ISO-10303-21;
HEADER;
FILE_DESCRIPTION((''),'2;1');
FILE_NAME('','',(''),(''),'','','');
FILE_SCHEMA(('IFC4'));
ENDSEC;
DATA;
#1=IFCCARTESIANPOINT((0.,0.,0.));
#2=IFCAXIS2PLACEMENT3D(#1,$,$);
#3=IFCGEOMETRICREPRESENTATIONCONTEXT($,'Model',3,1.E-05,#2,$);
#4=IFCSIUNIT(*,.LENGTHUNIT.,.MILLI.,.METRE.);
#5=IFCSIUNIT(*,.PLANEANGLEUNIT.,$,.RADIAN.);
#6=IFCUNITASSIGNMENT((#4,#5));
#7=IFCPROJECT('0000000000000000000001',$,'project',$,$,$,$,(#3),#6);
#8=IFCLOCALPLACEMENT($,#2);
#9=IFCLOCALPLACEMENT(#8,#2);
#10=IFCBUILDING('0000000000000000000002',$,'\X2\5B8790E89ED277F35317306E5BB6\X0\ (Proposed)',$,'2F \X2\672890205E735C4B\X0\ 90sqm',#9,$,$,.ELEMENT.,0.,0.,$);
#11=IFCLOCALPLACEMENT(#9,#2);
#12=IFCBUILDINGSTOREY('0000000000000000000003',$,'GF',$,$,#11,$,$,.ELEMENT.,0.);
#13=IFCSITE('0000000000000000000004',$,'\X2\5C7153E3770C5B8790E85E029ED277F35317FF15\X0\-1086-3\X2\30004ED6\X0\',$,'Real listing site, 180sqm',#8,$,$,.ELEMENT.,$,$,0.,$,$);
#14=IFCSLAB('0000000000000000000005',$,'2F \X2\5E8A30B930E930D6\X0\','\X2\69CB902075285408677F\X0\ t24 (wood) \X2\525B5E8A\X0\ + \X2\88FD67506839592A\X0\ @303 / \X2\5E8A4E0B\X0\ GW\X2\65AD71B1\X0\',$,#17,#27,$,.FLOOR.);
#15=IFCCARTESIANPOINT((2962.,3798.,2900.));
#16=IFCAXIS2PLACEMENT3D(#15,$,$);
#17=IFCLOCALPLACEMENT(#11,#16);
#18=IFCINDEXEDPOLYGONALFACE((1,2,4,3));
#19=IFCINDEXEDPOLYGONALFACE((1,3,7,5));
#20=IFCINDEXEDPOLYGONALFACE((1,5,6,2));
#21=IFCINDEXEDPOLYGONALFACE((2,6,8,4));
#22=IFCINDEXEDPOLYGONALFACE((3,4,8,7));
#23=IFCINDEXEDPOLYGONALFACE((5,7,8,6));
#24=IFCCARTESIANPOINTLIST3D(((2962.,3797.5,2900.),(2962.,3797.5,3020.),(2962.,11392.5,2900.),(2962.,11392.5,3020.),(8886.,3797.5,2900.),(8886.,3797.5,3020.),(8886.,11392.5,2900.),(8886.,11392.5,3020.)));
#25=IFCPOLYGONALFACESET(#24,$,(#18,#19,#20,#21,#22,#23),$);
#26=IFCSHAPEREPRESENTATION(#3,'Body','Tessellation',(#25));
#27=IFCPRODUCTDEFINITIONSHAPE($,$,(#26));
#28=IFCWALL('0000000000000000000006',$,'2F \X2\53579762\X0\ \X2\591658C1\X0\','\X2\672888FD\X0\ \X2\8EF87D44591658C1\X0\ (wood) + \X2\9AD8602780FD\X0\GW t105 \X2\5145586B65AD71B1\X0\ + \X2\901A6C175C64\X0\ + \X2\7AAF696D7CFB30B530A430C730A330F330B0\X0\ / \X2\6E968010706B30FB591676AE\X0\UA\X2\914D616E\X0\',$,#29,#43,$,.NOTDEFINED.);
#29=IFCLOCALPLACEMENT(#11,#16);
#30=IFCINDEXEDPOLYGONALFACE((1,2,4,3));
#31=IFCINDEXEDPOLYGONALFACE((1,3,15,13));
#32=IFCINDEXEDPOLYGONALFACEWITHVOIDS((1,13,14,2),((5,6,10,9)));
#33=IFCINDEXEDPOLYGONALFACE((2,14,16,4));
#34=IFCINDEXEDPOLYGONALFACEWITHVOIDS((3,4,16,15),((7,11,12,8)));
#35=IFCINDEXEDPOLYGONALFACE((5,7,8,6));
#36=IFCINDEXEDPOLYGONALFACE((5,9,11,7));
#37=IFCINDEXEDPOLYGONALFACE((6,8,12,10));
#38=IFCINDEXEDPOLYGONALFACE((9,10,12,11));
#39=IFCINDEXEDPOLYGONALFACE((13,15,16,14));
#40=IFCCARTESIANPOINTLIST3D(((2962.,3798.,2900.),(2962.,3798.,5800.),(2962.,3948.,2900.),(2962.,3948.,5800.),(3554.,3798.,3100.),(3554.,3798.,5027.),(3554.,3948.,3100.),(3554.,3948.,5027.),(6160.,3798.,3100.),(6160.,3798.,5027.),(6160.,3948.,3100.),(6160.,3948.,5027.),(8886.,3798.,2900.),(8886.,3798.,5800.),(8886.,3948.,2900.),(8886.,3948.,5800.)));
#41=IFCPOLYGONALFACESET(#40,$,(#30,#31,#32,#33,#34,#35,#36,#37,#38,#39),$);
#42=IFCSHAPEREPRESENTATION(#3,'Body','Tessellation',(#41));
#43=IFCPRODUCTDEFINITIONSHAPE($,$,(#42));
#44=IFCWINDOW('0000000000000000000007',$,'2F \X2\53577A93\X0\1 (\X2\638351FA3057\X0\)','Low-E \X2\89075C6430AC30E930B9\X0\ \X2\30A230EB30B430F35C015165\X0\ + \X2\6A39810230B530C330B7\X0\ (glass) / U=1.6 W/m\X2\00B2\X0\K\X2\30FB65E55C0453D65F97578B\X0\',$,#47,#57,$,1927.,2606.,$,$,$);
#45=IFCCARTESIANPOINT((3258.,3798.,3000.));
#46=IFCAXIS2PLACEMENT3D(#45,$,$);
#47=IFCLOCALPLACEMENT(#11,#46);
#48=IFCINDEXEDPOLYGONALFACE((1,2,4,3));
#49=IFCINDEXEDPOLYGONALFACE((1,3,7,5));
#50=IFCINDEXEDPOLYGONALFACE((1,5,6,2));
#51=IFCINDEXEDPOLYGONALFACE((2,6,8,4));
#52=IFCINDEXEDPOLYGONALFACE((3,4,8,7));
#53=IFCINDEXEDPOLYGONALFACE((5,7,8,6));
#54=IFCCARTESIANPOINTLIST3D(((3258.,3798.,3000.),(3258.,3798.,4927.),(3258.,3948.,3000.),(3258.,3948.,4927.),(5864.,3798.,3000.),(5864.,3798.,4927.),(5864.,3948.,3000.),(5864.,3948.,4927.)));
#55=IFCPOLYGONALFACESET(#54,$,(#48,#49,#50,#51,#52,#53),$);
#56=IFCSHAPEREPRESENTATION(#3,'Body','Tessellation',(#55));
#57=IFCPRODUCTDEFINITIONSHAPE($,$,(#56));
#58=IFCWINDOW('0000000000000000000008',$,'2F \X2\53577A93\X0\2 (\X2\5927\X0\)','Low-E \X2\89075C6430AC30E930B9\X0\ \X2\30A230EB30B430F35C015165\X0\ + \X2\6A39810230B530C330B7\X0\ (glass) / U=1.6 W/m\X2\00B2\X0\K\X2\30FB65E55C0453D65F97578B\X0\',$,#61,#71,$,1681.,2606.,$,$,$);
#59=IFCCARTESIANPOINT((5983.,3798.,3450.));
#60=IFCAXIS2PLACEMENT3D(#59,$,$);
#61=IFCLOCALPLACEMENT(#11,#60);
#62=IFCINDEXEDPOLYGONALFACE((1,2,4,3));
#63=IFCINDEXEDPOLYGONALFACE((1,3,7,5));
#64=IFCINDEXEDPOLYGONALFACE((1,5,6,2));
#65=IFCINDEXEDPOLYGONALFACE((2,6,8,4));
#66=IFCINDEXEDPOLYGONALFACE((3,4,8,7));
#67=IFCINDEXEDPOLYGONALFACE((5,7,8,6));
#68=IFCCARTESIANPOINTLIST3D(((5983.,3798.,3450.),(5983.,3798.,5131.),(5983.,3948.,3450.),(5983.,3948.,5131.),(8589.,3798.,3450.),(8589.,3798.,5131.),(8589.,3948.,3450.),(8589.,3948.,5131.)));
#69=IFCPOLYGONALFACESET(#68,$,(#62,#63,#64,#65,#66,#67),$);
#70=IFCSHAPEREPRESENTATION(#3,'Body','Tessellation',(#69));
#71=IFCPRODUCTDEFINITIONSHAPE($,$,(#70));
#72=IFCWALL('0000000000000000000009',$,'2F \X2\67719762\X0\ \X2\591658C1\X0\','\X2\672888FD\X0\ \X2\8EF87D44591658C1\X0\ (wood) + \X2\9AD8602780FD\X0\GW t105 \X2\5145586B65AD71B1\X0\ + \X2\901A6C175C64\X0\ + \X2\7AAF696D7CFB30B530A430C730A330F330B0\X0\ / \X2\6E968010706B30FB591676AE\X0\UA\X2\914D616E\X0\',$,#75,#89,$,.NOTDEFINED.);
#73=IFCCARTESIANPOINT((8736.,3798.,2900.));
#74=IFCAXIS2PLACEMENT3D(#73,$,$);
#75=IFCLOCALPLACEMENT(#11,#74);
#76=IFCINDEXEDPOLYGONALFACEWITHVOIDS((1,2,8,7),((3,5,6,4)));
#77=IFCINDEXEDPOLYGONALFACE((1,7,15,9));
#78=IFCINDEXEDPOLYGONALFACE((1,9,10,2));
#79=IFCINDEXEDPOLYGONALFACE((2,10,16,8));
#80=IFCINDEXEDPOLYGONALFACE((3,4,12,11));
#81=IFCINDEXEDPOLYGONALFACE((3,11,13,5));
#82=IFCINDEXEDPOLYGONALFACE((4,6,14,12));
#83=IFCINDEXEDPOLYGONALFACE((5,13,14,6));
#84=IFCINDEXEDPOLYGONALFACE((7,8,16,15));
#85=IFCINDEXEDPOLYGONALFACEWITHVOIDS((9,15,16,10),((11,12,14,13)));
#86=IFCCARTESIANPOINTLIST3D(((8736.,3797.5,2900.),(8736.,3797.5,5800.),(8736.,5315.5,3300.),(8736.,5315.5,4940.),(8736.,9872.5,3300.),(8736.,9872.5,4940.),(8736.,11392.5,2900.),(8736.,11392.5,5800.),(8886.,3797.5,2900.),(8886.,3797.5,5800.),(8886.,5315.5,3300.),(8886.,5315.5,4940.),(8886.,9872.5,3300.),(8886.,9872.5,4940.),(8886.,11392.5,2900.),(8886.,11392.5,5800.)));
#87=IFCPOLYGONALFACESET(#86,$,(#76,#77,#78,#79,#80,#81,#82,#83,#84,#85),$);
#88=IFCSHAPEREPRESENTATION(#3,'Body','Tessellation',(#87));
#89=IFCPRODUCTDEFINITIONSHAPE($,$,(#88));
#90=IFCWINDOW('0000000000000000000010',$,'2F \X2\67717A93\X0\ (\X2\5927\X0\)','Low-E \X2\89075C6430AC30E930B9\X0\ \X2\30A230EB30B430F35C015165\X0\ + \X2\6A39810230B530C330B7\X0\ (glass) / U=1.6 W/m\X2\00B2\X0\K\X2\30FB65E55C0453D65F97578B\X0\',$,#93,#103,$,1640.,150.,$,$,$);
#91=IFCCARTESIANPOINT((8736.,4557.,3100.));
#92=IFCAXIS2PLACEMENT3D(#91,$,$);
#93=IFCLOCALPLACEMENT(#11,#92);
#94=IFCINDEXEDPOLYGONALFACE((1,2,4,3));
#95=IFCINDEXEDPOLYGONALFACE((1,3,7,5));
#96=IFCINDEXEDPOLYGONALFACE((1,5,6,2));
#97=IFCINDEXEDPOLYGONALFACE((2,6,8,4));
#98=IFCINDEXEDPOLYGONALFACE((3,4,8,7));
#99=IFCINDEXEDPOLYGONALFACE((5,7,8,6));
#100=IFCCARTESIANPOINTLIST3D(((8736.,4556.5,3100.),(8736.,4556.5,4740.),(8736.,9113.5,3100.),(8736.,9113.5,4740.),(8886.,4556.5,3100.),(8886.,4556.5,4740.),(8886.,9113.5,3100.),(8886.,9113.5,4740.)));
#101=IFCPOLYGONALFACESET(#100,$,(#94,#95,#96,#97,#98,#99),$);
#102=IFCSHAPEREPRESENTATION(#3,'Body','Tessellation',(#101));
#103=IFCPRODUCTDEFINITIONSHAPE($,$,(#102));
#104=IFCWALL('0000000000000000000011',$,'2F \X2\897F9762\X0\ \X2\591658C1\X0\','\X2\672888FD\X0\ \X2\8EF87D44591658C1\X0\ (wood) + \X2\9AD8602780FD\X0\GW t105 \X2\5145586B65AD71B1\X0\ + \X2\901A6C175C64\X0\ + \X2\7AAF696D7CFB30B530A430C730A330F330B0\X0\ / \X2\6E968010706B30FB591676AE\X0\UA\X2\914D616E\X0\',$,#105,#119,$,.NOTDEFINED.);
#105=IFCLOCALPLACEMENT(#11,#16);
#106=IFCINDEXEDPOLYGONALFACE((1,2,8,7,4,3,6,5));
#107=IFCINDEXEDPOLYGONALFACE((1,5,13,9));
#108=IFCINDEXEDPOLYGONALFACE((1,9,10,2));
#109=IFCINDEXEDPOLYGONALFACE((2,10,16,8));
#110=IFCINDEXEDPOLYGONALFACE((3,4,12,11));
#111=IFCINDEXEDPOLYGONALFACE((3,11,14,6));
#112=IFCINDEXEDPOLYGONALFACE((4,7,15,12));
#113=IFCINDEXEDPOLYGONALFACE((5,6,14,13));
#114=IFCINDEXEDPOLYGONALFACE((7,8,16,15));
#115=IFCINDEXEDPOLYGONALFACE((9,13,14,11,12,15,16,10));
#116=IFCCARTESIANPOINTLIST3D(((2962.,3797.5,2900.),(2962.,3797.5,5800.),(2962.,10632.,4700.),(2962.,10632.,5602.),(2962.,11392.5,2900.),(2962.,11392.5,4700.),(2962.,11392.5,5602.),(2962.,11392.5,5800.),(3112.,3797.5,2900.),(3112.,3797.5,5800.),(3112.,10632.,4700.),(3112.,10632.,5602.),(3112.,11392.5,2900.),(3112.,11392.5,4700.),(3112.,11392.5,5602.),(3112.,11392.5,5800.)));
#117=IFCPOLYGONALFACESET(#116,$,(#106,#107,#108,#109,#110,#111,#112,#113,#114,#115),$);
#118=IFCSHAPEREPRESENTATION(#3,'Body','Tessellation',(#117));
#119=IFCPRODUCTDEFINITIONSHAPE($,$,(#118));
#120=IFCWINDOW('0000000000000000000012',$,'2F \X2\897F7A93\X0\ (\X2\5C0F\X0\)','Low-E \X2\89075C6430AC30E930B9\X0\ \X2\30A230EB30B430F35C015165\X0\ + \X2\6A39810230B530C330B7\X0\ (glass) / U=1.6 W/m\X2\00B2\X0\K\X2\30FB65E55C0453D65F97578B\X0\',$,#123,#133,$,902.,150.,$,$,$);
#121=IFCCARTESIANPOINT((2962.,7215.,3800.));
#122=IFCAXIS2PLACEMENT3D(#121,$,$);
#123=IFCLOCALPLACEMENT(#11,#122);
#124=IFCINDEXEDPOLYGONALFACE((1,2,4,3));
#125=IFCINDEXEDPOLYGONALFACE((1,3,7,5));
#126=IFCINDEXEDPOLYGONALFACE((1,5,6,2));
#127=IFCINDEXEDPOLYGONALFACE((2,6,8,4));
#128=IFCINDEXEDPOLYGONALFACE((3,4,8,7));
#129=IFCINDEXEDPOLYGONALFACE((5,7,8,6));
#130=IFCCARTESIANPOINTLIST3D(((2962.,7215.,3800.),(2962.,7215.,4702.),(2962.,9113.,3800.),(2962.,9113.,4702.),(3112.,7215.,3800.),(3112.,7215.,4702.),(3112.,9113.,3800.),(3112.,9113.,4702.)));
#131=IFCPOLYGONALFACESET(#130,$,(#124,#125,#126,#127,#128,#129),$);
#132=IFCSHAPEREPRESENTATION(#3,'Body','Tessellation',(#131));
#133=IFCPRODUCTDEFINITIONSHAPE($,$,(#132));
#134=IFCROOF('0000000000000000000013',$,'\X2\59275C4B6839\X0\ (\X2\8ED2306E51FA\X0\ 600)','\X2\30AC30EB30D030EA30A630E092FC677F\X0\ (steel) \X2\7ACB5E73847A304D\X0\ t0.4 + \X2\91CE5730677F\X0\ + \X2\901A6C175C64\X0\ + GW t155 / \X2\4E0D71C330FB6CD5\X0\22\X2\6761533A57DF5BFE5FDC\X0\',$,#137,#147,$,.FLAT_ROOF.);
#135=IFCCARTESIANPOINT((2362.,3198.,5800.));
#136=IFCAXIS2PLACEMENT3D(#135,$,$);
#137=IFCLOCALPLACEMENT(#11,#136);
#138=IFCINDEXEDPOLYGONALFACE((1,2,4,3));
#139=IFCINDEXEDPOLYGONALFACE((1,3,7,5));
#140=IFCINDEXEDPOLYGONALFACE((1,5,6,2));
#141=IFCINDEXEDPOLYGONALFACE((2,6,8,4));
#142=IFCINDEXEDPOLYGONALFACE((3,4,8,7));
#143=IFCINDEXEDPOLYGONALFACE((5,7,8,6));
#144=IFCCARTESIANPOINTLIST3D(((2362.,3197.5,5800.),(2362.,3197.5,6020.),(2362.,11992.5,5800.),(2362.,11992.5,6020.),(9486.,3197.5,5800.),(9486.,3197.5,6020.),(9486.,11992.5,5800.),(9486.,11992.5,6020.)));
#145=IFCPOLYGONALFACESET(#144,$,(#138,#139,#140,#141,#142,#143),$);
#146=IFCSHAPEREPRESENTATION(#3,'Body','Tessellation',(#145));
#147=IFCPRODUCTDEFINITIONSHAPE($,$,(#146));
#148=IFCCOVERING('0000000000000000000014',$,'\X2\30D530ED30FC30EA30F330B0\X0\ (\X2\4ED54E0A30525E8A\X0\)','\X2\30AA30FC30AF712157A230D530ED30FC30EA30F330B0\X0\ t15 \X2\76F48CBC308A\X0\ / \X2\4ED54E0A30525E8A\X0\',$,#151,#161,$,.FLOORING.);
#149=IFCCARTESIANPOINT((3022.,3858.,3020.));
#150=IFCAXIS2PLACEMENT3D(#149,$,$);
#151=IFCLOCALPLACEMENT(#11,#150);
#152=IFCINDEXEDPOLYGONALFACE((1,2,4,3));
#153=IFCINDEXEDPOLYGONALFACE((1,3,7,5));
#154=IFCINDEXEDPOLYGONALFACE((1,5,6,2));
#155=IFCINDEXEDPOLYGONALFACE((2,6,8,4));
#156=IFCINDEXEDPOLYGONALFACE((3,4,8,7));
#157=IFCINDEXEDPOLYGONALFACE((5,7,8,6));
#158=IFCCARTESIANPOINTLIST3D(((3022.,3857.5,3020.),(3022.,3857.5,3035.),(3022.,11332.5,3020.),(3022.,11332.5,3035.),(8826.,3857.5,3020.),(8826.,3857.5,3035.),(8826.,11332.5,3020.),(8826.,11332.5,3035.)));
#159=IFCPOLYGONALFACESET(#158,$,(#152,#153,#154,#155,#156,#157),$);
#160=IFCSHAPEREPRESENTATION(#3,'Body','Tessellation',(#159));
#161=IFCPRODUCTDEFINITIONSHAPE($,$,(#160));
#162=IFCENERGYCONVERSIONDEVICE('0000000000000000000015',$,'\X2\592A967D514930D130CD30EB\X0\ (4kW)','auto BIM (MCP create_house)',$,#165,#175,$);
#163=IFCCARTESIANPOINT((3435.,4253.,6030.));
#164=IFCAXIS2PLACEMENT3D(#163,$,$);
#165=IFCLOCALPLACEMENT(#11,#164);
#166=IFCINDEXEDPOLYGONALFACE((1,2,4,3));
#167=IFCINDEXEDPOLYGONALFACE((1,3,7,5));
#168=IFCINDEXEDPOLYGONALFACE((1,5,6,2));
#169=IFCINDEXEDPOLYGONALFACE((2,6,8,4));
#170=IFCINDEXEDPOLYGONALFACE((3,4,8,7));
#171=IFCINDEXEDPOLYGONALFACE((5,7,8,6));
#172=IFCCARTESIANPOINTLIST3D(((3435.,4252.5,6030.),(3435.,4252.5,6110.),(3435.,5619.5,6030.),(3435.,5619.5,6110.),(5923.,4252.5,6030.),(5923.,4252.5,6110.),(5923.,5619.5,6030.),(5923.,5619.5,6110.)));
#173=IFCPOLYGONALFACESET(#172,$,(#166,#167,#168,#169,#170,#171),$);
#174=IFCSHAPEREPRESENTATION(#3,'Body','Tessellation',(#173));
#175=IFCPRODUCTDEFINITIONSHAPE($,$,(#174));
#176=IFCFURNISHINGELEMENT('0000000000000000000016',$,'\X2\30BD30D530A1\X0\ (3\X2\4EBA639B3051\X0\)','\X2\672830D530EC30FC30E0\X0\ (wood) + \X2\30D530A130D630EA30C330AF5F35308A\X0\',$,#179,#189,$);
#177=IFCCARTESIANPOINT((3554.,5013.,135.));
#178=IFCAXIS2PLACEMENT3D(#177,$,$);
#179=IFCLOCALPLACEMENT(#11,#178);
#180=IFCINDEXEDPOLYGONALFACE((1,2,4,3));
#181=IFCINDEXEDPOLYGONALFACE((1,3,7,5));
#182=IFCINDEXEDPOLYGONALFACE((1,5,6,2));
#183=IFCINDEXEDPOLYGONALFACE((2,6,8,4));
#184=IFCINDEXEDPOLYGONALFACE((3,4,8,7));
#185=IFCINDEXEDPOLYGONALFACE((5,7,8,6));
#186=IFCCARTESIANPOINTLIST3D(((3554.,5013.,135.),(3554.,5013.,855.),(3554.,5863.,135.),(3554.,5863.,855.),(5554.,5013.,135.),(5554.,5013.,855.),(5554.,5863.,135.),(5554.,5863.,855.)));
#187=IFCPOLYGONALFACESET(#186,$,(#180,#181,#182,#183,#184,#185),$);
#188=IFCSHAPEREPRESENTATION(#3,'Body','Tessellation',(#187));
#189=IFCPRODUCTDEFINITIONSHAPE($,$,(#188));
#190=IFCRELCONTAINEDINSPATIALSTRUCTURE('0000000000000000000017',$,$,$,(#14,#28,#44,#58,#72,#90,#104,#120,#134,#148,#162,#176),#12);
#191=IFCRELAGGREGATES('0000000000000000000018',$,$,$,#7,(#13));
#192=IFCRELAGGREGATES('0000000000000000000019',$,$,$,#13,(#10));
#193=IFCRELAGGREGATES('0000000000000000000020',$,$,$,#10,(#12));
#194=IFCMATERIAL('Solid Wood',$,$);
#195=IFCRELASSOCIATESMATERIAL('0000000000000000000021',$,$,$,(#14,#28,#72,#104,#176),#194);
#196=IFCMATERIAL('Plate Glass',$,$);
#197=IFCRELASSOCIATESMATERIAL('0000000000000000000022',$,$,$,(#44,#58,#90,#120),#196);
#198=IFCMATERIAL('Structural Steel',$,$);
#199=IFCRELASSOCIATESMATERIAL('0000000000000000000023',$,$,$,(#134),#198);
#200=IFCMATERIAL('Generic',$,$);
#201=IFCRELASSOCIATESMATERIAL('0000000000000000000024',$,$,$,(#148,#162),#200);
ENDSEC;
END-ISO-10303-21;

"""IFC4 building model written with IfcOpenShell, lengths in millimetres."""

from ifc_helpers import new_model, si_unit, frame, frame_2d, origin, place, context, project, spatial, rectangle, extrude, material, element, fill, save


model = new_model("IFC4")

# Units and contexts
model_context = context("Model", 3, precision=1e-05, world=origin())
ifc_project = project(units=[si_unit("LENGTHUNIT", "METRE", prefix="MILLI"), si_unit("PLANEANGLEUNIT", "RADIAN")], contexts=[model_context])

# Site, building, storey
site_placement = place(None, origin())
site = spatial("IfcSite", under=ifc_project, at=site_placement, Name="山口県宇部市黒石北５-1086-3　他", ObjectType="Real listing site, 180sqm", CompositionType="ELEMENT", RefElevation=0.0)
building_placement = place(site_placement, origin())
building = spatial("IfcBuilding", under=site, at=building_placement, Name="宇部黒石北の家 (Proposed)", ObjectType="2F 木造平屋 90sqm", CompositionType="ELEMENT", ElevationOfRefHeight=0.0, ElevationOfTerrain=0.0)
storey_placement = place(building_placement, origin())
storey = spatial("IfcBuildingStorey", under=building, at=storey_placement, Name="GF", CompositionType="ELEMENT", Elevation=0.0)

# Slab
ifc_material_1 = material(Name="Solid Wood")
slab_placement = place(storey_placement, frame((2962.0, 3798.0, 2900.0)))
element("IfcSlab", 1, at=slab_placement, inside=storey, material=ifc_material_1, Name="2F 床スラブ", Description="構造用合板 t24 (wood) 剛床 + 製材根太 @303 / 床下 GW断熱", PredefinedType="FLOOR", context=model_context, shape_type="SweptSolid", body=[
    extrude(rectangle(XDim=5924.0, YDim=7595.0, at=frame_2d((2962.0, 3797.0))), frame((2962.0, 3798.0, 2900.0)), (0.0, 0.0, 1.0), 120.0),
])

# Wall, openings, windows
wall_1_placement = place(storey_placement, frame((2962.0, 3798.0, 2900.0)))
wall_1 = element("IfcWall", 2, at=wall_1_placement, inside=storey, material=ifc_material_1, Name="2F 南面 外壁", Description="木製 軸組外壁 (wood) + 高性能GW t105 充填断熱 + 通気層 + 窯業系サイディング / 準耐火・外皮UA配慮", PredefinedType="NOTDEFINED", context=model_context, shape_type="SweptSolid", body=[
    extrude(rectangle(XDim=5924.0, YDim=150.0, at=frame_2d((2962.0, 75.0))), frame((2962.0, 3798.0, 2900.0)), (0.0, 0.0, 1.0), 2900.0),
])
opening_1_placement = place(storey_placement, frame((3258.0, 3798.0, 3000.0)))
opening_1 = element("IfcOpeningElement", 3, at=opening_1_placement, cuts=wall_1, PredefinedType="NOTDEFINED", context=model_context, shape_type="SweptSolid", body=[
    extrude(rectangle(XDim=2606.0, YDim=150.0, at=frame_2d((1303.0, 75.0))), frame((3258.0, 3798.0, 3000.0)), (0.0, 0.0, 1.0), 1927.0),
])
opening_2_placement = place(storey_placement, frame((5983.0, 3798.0, 3450.0)))
opening_2 = element("IfcOpeningElement", 4, at=opening_2_placement, cuts=wall_1, PredefinedType="NOTDEFINED", context=model_context, shape_type="SweptSolid", body=[
    extrude(rectangle(XDim=2606.0, YDim=150.0, at=frame_2d((1303.0, 75.0))), frame((5983.0, 3798.0, 3450.0)), (0.0, 0.0, 1.0), 1681.0),
])
ifc_material_2 = material(Name="Plate Glass")
window_1_placement = place(storey_placement, frame((3258.0, 3798.0, 3000.0)))
window_1 = element("IfcWindow", 5, at=window_1_placement, inside=storey, material=ifc_material_2, Name="2F 南窓1 (掃出し)", Description="Low-E 複層ガラス アルゴン封入 + 樹脂サッシ (glass) / U=1.6 W/m²K・日射取得型", OverallHeight=1927.0, OverallWidth=2606.0, context=model_context, shape_type="SweptSolid", body=[
    extrude(rectangle(XDim=2606.0, YDim=150.0, at=frame_2d((1303.0, 75.0))), frame((3258.0, 3798.0, 3000.0)), (0.0, 0.0, 1.0), 1927.0),
])
fill(opening_1, window_1)
window_2_placement = place(storey_placement, frame((5983.0, 3798.0, 3450.0)))
window_2 = element("IfcWindow", 6, at=window_2_placement, inside=storey, material=ifc_material_2, Name="2F 南窓2 (大)", Description="Low-E 複層ガラス アルゴン封入 + 樹脂サッシ (glass) / U=1.6 W/m²K・日射取得型", OverallHeight=1681.0, OverallWidth=2606.0, context=model_context, shape_type="SweptSolid", body=[
    extrude(rectangle(XDim=2606.0, YDim=150.0, at=frame_2d((1303.0, 75.0))), frame((5983.0, 3798.0, 3450.0)), (0.0, 0.0, 1.0), 1681.0),
])
fill(opening_2, window_2)

# Walls, openings, windows
wall_2_placement = place(storey_placement, frame((8736.0, 3798.0, 2900.0)))
wall_2 = element("IfcWall", 7, at=wall_2_placement, inside=storey, material=ifc_material_1, Name="2F 東面 外壁", Description="木製 軸組外壁 (wood) + 高性能GW t105 充填断熱 + 通気層 + 窯業系サイディング / 準耐火・外皮UA配慮", PredefinedType="NOTDEFINED", context=model_context, shape_type="SweptSolid", body=[
    extrude(rectangle(XDim=150.0, YDim=7595.0, at=frame_2d((75.0, 3797.0))), frame((8736.0, 3798.0, 2900.0)), (0.0, 0.0, 1.0), 2900.0),
])
opening_3_placement = place(storey_placement, frame((8736.0, 4557.0, 3100.0)))
opening_3 = element("IfcOpeningElement", 8, at=opening_3_placement, cuts=wall_2, PredefinedType="NOTDEFINED", context=model_context, shape_type="SweptSolid", body=[
    extrude(rectangle(XDim=150.0, YDim=4557.0, at=frame_2d((75.0, 2278.0))), frame((8736.0, 4557.0, 3100.0)), (0.0, 0.0, 1.0), 1640.0),
])
window_3_placement = place(storey_placement, frame((8736.0, 4557.0, 3100.0)))
window_3 = element("IfcWindow", 9, at=window_3_placement, inside=storey, material=ifc_material_2, Name="2F 東窓 (大)", Description="Low-E 複層ガラス アルゴン封入 + 樹脂サッシ (glass) / U=1.6 W/m²K・日射取得型", OverallHeight=1640.0, OverallWidth=150.0, context=model_context, shape_type="SweptSolid", body=[
    extrude(rectangle(XDim=150.0, YDim=4557.0, at=frame_2d((75.0, 2278.0))), frame((8736.0, 4557.0, 3100.0)), (0.0, 0.0, 1.0), 1640.0),
])
fill(opening_3, window_3)
wall_3_placement = place(storey_placement, frame((2962.0, 3798.0, 2900.0)))
wall_3 = element("IfcWall", 10, at=wall_3_placement, inside=storey, material=ifc_material_1, Name="2F 西面 外壁", Description="木製 軸組外壁 (wood) + 高性能GW t105 充填断熱 + 通気層 + 窯業系サイディング / 準耐火・外皮UA配慮", PredefinedType="NOTDEFINED", context=model_context, shape_type="SweptSolid", body=[
    extrude(rectangle(XDim=150.0, YDim=7595.0, at=frame_2d((75.0, 3797.0))), frame((2962.0, 3798.0, 2900.0)), (0.0, 0.0, 1.0), 2900.0),
])
opening_4_placement = place(storey_placement, frame((2962.0, 7215.0, 3800.0)))
opening_4 = element("IfcOpeningElement", 11, at=opening_4_placement, cuts=wall_3, PredefinedType="NOTDEFINED", context=model_context, shape_type="SweptSolid", body=[
    extrude(rectangle(XDim=150.0, YDim=1898.0, at=frame_2d((75.0, 949.0))), frame((2962.0, 7215.0, 3800.0)), (0.0, 0.0, 1.0), 902.0),
])
window_4_placement = place(storey_placement, frame((2962.0, 7215.0, 3800.0)))
window_4 = element("IfcWindow", 12, at=window_4_placement, inside=storey, material=ifc_material_2, Name="2F 西窓 (小)", Description="Low-E 複層ガラス アルゴン封入 + 樹脂サッシ (glass) / U=1.6 W/m²K・日射取得型", OverallHeight=902.0, OverallWidth=150.0, context=model_context, shape_type="SweptSolid", body=[
    extrude(rectangle(XDim=150.0, YDim=1898.0, at=frame_2d((75.0, 949.0))), frame((2962.0, 7215.0, 3800.0)), (0.0, 0.0, 1.0), 902.0),
])
fill(opening_4, window_4)

# Roof
ifc_material_3 = material(Name="Structural Steel")
roof_placement = place(storey_placement, frame((2362.0, 3198.0, 5800.0)))
element("IfcRoof", 13, at=roof_placement, inside=storey, material=ifc_material_3, Name="大屋根 (軒の出 600)", Description="ガルバリウム鋼板 (steel) 立平葺き t0.4 + 野地板 + 通気層 + GW t155 / 不燃・法22条区域対応", PredefinedType="FLAT_ROOF", context=model_context, shape_type="SweptSolid", body=[
    extrude(rectangle(XDim=7124.0, YDim=8795.0, at=frame_2d((3562.0, 4397.0))), frame((2362.0, 3198.0, 5800.0)), (0.0, 0.0, 1.0), 220.0),
])

# Covering
ifc_material_4 = material(Name="Generic")
covering_placement = place(storey_placement, frame((3022.0, 3858.0, 3020.0)))
element("IfcCovering", 14, at=covering_placement, inside=storey, material=ifc_material_4, Name="フローリング (仕上げ床)", Description="オーク無垢フローリング t15 直貼り / 仕上げ床", PredefinedType="FLOORING", context=model_context, shape_type="SweptSolid", body=[
    extrude(rectangle(XDim=5804.0, YDim=7475.0, at=frame_2d((2902.0, 3737.0))), frame((3022.0, 3858.0, 3020.0)), (0.0, 0.0, 1.0), 15.0),
])

# Energy conversion device
energy_conversion_device_placement = place(storey_placement, frame((3435.0, 4253.0, 6030.0)))
element("IfcEnergyConversionDevice", 15, at=energy_conversion_device_placement, inside=storey, material=ifc_material_4, Name="太陽光パネル (4kW)", Description="auto BIM (MCP create_house)", context=model_context, shape_type="SweptSolid", body=[
    extrude(rectangle(XDim=2488.0, YDim=1367.0, at=frame_2d((1244.0, 683.0))), frame((3435.0, 4253.0, 6030.0)), (0.0, 0.0, 1.0), 80.0),
])

# Furnishing element
furnishing_1_placement = place(storey_placement, frame((3554.0, 5013.0, 135.0)))
element("IfcFurnishingElement", 16, at=furnishing_1_placement, inside=storey, material=ifc_material_1, Name="ソファ (3人掛け)", Description="木フレーム (wood) + ファブリック張り", context=model_context, shape_type="SweptSolid", body=[
    extrude(rectangle(XDim=2000.0, YDim=850.0, at=frame_2d((1000.0, 425.0))), frame((3554.0, 5013.0, 135.0)), (0.0, 0.0, 1.0), 720.0),
])

save(model, "model.ifc")
